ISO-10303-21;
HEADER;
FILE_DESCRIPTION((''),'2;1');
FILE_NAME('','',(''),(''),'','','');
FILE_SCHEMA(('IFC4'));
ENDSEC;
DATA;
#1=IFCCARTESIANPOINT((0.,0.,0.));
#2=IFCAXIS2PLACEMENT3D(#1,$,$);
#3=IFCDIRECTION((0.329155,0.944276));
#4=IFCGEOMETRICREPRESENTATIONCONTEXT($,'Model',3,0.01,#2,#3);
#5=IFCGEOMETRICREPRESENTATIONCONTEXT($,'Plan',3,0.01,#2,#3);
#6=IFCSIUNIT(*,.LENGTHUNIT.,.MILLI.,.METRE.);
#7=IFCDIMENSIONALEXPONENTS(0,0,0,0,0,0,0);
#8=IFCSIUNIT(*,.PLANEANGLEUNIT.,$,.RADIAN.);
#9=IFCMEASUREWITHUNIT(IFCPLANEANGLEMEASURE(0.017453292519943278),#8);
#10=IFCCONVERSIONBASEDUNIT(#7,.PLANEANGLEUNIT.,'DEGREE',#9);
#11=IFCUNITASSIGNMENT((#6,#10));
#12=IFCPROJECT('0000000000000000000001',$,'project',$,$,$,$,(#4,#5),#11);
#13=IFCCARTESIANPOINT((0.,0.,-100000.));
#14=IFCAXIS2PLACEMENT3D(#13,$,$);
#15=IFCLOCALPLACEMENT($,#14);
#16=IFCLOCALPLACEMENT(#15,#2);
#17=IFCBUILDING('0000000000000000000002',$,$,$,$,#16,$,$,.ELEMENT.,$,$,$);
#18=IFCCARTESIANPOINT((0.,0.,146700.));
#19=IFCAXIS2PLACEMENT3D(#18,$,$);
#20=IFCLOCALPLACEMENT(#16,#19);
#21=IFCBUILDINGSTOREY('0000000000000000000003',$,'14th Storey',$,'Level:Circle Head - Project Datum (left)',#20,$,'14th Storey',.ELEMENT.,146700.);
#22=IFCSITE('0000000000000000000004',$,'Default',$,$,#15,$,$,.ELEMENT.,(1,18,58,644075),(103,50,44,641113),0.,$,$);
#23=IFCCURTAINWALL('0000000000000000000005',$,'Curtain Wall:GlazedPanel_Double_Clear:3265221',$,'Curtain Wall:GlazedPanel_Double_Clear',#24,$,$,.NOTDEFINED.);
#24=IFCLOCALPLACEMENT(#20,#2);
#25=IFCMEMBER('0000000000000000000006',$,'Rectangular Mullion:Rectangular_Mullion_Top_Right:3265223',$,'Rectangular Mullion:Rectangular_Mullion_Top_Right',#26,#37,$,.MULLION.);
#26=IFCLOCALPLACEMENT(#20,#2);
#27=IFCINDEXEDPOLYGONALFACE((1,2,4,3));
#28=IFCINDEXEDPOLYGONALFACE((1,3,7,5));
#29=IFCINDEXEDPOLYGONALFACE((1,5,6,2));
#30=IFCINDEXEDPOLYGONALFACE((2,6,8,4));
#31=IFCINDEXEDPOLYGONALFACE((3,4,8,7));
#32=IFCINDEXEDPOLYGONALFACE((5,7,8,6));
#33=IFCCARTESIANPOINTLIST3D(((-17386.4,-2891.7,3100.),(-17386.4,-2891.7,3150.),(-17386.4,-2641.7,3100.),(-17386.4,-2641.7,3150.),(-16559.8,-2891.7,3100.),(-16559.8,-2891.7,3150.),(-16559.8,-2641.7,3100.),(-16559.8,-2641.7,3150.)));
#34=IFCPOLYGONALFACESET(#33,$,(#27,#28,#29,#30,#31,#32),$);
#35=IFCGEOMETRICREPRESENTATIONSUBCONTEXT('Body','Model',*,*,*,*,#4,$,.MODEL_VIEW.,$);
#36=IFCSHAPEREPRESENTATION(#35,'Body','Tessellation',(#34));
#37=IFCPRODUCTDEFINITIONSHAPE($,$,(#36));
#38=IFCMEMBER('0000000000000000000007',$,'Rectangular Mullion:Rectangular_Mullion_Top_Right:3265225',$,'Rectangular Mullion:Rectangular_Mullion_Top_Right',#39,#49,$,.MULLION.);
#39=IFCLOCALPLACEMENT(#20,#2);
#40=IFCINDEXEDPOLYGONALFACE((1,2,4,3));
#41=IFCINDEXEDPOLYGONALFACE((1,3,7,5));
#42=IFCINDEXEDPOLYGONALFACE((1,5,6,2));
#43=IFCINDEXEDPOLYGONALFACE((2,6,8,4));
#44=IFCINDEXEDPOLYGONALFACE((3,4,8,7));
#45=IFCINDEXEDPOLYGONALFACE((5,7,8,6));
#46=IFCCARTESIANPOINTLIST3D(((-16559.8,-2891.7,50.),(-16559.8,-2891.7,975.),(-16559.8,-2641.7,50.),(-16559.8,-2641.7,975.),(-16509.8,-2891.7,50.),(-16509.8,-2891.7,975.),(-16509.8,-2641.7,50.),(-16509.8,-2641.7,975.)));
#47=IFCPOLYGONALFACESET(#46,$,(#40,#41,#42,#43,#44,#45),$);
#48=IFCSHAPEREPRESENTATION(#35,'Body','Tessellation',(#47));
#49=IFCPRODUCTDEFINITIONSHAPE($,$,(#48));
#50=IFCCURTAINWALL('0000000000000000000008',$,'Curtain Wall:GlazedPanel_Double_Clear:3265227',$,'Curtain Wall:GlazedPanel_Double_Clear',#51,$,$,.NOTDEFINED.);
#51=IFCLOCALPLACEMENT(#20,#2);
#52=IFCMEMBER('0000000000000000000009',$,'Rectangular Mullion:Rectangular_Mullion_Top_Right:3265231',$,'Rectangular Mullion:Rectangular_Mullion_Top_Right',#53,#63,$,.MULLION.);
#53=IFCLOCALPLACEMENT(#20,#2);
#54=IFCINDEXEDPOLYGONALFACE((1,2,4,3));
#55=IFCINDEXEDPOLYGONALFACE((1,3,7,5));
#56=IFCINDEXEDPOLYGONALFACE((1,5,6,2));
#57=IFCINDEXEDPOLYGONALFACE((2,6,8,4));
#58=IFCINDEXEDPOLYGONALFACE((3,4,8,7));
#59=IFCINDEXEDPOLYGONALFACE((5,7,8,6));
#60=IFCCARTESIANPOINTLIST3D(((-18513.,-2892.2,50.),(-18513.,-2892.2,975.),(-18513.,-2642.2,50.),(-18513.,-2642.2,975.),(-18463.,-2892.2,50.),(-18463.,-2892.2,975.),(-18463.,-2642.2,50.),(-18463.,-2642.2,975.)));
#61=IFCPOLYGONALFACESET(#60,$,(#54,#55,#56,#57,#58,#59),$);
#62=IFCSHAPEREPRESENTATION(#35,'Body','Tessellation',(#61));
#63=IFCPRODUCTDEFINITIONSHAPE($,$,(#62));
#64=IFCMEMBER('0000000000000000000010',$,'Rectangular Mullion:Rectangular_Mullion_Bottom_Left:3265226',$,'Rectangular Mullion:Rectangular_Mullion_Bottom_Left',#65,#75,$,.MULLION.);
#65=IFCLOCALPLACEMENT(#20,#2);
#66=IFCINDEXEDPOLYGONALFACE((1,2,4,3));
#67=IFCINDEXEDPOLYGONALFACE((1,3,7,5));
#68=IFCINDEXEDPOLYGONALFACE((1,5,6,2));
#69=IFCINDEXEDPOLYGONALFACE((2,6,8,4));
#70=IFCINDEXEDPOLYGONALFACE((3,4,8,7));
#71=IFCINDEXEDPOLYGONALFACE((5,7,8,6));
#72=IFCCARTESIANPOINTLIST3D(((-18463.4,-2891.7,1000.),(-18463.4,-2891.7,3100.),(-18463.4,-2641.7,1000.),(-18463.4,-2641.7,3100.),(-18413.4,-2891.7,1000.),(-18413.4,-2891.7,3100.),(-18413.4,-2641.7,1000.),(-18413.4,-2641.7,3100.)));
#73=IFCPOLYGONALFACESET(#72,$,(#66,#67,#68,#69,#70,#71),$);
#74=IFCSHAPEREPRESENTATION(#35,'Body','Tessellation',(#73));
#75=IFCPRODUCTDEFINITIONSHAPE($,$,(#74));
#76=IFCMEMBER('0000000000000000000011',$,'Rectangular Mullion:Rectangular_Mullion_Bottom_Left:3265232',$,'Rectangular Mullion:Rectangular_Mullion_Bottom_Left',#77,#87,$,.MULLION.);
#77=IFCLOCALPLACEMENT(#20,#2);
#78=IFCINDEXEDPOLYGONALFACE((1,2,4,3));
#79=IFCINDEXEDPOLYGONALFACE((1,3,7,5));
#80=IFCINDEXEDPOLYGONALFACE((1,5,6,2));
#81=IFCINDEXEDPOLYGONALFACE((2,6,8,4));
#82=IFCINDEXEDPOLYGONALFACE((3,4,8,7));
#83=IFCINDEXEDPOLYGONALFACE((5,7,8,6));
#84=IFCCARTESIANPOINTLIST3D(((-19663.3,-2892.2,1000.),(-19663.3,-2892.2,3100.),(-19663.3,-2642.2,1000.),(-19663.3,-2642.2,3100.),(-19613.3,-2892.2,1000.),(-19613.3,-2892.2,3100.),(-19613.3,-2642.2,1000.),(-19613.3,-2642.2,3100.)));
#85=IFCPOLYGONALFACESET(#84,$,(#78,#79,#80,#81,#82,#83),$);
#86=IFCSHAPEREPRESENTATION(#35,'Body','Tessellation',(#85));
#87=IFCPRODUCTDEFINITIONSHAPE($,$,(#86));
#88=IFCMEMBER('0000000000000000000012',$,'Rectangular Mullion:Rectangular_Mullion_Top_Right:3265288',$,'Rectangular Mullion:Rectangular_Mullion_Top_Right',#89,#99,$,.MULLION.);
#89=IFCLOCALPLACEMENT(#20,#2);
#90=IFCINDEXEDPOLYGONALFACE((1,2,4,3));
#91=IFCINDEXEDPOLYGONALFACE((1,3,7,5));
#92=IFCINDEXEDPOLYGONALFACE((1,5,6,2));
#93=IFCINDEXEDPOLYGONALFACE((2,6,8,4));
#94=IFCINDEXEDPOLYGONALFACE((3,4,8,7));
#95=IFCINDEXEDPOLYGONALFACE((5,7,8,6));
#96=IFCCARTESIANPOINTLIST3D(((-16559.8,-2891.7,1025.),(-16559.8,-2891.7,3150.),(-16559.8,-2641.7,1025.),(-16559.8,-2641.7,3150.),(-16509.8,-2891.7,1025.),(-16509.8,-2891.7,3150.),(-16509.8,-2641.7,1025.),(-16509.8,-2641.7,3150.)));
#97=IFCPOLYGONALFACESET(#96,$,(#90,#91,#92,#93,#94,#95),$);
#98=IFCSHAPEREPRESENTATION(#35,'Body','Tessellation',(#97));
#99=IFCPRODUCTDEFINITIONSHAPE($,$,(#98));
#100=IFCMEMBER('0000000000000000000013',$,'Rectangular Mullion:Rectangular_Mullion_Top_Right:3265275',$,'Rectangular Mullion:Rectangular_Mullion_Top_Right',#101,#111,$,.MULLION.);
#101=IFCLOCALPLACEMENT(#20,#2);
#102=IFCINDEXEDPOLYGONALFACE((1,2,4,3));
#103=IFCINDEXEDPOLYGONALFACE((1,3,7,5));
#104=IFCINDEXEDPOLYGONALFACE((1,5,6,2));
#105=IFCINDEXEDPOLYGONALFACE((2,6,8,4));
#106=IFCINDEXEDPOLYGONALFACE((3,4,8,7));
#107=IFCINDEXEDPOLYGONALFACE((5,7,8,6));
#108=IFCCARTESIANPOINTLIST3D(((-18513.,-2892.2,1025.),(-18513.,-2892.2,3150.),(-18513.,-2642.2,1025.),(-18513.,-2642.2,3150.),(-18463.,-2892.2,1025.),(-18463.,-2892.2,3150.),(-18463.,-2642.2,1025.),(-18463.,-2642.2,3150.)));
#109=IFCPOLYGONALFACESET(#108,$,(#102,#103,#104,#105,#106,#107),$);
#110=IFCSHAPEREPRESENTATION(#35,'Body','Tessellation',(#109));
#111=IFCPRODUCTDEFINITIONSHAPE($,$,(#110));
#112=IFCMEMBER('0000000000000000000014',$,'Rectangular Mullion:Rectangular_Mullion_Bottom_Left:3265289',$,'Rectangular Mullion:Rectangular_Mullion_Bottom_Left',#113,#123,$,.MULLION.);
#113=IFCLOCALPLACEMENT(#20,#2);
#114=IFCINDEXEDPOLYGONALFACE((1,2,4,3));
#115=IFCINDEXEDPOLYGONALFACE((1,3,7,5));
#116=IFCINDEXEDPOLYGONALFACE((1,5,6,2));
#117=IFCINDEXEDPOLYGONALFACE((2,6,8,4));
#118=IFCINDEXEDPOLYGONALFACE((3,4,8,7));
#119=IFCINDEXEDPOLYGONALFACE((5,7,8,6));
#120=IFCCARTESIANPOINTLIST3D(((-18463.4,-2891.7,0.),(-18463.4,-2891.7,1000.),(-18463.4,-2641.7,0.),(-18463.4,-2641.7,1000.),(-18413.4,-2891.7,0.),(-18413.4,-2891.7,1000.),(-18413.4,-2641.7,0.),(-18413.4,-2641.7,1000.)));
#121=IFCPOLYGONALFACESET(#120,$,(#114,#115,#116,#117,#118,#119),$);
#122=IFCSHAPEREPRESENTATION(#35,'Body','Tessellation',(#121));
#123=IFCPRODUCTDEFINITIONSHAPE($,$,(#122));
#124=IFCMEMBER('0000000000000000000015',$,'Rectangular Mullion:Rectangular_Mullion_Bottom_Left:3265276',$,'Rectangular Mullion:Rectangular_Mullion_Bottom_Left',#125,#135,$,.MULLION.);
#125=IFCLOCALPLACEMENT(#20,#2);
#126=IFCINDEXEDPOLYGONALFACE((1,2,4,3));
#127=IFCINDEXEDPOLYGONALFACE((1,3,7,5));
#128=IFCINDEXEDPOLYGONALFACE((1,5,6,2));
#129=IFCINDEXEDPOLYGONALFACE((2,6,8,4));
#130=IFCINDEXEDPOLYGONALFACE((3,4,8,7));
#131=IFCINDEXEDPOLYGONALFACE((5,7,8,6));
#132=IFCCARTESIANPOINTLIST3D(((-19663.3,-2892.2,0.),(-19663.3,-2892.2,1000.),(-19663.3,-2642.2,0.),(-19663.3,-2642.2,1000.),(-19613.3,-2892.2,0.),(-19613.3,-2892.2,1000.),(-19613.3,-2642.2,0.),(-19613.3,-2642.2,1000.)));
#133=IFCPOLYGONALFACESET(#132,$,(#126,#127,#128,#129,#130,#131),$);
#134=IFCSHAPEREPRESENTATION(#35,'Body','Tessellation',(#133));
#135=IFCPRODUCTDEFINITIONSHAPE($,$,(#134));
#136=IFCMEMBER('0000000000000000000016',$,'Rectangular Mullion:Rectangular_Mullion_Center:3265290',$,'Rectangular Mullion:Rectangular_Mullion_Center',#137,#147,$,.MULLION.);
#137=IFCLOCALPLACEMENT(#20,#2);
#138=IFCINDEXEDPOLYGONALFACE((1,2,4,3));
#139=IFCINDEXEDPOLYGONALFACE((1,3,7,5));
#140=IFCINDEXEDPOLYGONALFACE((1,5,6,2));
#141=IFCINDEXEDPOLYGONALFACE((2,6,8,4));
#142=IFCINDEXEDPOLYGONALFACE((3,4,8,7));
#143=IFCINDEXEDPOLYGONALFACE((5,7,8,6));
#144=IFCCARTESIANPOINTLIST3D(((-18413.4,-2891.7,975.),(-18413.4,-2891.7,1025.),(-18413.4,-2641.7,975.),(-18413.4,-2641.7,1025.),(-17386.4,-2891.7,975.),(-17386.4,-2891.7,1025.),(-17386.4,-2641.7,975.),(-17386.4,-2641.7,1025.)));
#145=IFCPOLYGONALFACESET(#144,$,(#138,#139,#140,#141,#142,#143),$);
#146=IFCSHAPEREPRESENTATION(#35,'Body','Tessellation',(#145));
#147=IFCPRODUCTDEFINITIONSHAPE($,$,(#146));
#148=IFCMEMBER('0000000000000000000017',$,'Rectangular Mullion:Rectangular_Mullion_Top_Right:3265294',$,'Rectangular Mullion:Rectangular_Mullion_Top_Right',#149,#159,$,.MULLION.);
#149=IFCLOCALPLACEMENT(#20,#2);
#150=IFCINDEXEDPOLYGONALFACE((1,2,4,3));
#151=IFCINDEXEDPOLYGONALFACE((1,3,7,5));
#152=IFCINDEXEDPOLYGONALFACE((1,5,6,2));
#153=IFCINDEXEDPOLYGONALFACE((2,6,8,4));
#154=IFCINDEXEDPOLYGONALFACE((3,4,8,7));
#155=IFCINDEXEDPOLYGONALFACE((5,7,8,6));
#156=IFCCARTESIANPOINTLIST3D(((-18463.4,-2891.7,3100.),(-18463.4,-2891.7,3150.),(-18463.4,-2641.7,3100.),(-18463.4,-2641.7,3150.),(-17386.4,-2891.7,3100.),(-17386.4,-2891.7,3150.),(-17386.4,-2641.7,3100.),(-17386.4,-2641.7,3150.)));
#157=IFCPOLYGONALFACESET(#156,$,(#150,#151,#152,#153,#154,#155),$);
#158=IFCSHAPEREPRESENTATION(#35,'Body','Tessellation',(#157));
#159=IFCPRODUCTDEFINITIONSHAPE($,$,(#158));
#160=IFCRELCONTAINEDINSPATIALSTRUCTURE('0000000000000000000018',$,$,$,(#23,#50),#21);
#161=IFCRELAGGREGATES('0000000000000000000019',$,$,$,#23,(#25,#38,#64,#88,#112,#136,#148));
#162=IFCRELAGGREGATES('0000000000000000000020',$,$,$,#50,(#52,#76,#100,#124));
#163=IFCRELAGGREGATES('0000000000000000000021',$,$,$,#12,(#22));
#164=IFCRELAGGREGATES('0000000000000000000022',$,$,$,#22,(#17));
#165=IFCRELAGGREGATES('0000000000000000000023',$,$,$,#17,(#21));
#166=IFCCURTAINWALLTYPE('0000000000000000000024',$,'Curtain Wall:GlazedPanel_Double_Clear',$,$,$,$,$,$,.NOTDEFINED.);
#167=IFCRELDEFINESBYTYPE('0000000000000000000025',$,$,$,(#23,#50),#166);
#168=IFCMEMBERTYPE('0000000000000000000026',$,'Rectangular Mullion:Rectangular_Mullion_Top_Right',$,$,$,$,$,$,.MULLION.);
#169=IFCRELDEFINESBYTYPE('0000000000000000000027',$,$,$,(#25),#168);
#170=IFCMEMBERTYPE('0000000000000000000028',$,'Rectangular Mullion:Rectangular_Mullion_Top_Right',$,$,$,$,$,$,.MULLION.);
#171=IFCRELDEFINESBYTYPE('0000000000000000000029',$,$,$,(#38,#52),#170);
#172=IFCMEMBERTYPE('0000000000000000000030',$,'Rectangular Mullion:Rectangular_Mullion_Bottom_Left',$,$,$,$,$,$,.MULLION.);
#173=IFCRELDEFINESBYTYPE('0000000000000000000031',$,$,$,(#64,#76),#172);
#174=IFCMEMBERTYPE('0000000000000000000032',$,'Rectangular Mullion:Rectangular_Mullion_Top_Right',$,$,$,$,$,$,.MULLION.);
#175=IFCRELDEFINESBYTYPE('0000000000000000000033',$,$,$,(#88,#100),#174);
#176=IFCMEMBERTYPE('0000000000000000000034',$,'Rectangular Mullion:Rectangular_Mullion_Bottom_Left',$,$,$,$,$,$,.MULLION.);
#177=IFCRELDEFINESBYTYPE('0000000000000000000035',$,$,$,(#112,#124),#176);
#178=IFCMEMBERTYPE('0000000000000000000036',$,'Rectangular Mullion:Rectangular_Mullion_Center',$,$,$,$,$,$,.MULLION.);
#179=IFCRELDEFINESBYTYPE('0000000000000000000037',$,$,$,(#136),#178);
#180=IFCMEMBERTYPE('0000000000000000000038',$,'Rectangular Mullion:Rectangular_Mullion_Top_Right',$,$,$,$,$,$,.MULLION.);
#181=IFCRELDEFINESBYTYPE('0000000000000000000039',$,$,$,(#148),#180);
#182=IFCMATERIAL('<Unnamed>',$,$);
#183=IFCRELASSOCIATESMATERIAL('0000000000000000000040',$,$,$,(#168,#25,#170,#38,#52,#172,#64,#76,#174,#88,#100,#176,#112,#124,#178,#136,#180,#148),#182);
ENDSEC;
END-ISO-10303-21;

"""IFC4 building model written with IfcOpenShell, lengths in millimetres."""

from ifc_helpers import new_model, entity, si_unit, converted_unit, direction, frame, origin, place, context, subcontext, project, spatial, indexed_curve, outline, extrude, source, transform, mapped, material, type_object, type_shapes, element, aggregate, save


model = new_model("IFC4")

# Units and contexts
model_context = context("Model", 3, precision=0.01, world=origin(), true_north=direction((0.329155, 0.944276)))
plan_context = context("Plan", 3, precision=0.01, world=origin(), true_north=direction((0.329155, 0.944276)))
body_context = subcontext(model_context, "Body", "Model", "MODEL_VIEW")
ifc_project = project(units=[si_unit("LENGTHUNIT", "METRE", prefix="MILLI"), converted_unit("PLANEANGLEUNIT", "DEGREE", entity("IfcPlaneAngleMeasure", 0.017453292519943278), si_unit("PLANEANGLEUNIT", "RADIAN"), dimensions=[0, 0, 0, 0, 0, 0, 0])], contexts=[model_context, plan_context])

# Site, building, storey
site_placement = place(None, frame((0.0, 0.0, -100000.0)))
site = spatial("IfcSite", under=ifc_project, at=site_placement, Name="Default", CompositionType="ELEMENT", RefLatitude=(1, 18, 58, 644075), RefLongitude=(103, 50, 44, 641113), RefElevation=0.0)
building_placement = place(site_placement, origin())
building = spatial("IfcBuilding", under=site, at=building_placement, CompositionType="ELEMENT")
storey_placement = place(building_placement, frame((0.0, 0.0, 146700.0)))
storey = spatial("IfcBuildingStorey", under=building, at=storey_placement, Name="14th Storey", ObjectType="Level:Circle Head - Project Datum (left)", LongName="14th Storey", CompositionType="ELEMENT", Elevation=146700.0)

# Curtain wall, members
curtain_wall_type = type_object("IfcCurtainWallType", Name="Curtain Wall:GlazedPanel_Double_Clear", PredefinedType="NOTDEFINED")
curtain_wall_1_placement = place(storey_placement, frame((0.0, 0.0, -146700.0)))
curtain_wall_1 = element("IfcCurtainWall", 1, at=curtain_wall_1_placement, inside=storey, type_object=curtain_wall_type, Name="Curtain Wall:GlazedPanel_Double_Clear:3265221", ObjectType="Curtain Wall:GlazedPanel_Double_Clear", PredefinedType="NOTDEFINED")
ifc_material_1 = material(Name="<Unnamed>")
member_type_1 = type_object("IfcMemberType", Name="Rectangular Mullion:Rectangular_Mullion_Top_Right", PredefinedType="MULLION", material=ifc_material_1)
shared_shape_1 = source(origin(), body_context, "Body", "SweptSolid", [
    extrude(outline(indexed_curve([(-25.0, -125.0), (25.0, -125.0), (25.0, 125.0), (-25.0, 125.0), (-25.0, -125.0)], self_intersect=False)), frame((-25.0, 0.0, -826.6), z_axis=(0.0, 0.0, 1.0), x_axis=(-1.0, 0.0, 0.0)), (0.0, 0.0, 1.0), 826.6),
])
type_shapes(member_type_1, [shared_shape_1])
member_1_placement = place(curtain_wall_1_placement, frame((-16559.8, -2766.7, 149850.0), z_axis=(1.0, 0.0, 0.0), x_axis=(0.0, 0.0, 1.0)))
member_1 = element("IfcMember", 2, at=member_1_placement, type_object=member_type_1, material=ifc_material_1, Name="Rectangular Mullion:Rectangular_Mullion_Top_Right:3265223", ObjectType="Rectangular Mullion:Rectangular_Mullion_Top_Right", PredefinedType="MULLION", context=body_context, shape_type="MappedRepresentation", body=[
    mapped(shared_shape_1, transform((0.0, 0.0, 0.0), scale=1.0)),
])
member_type_2 = type_object("IfcMemberType", Name="Rectangular Mullion:Rectangular_Mullion_Top_Right", PredefinedType="MULLION", material=ifc_material_1)
shared_shape_2 = source(origin(), body_context, "Body", "SweptSolid", [
    extrude(outline(indexed_curve([(-25.0, -125.0), (25.0, -125.0), (25.0, 125.0), (-25.0, 125.0), (-25.0, -125.0)], self_intersect=False)), frame((-25.0, 0.0, -925.0), z_axis=(0.0, 0.0, 1.0), x_axis=(-1.0, 0.0, 0.0)), (0.0, 0.0, 1.0), 925.0),
])
type_shapes(member_type_2, [shared_shape_2])
member_2_placement = place(curtain_wall_1_placement, frame((-16509.8, -2766.7, 146750.0), z_axis=(0.0, 0.0, -1.0), x_axis=(1.0, 0.0, 0.0)))
member_2 = element("IfcMember", 3, at=member_2_placement, type_object=member_type_2, material=ifc_material_1, Name="Rectangular Mullion:Rectangular_Mullion_Top_Right:3265225", ObjectType="Rectangular Mullion:Rectangular_Mullion_Top_Right", PredefinedType="MULLION", context=body_context, shape_type="MappedRepresentation", body=[
    mapped(shared_shape_2, transform((0.0, 0.0, 0.0), scale=1.0)),
])

# Curtain wall, member
curtain_wall_2_placement = place(storey_placement, frame((0.0, 0.0, -146700.0)))
curtain_wall_2 = element("IfcCurtainWall", 4, at=curtain_wall_2_placement, inside=storey, type_object=curtain_wall_type, Name="Curtain Wall:GlazedPanel_Double_Clear:3265227", ObjectType="Curtain Wall:GlazedPanel_Double_Clear", PredefinedType="NOTDEFINED")
member_3_placement = place(curtain_wall_2_placement, frame((-18463.0, -2767.2, 146750.0), z_axis=(0.0, 0.0, -1.0), x_axis=(1.0, 0.0, 0.0)))
member_3 = element("IfcMember", 5, at=member_3_placement, type_object=member_type_2, material=ifc_material_1, Name="Rectangular Mullion:Rectangular_Mullion_Top_Right:3265231", ObjectType="Rectangular Mullion:Rectangular_Mullion_Top_Right", PredefinedType="MULLION", context=body_context, shape_type="MappedRepresentation", body=[
    mapped(shared_shape_2, transform((0.0, 0.0, 0.0), scale=1.0)),
])

# Members
member_type_3 = type_object("IfcMemberType", Name="Rectangular Mullion:Rectangular_Mullion_Bottom_Left", PredefinedType="MULLION", material=ifc_material_1)
shared_shape_3 = source(origin(), body_context, "Body", "SweptSolid", [
    extrude(outline(indexed_curve([(-25.0, -125.0), (25.0, -125.0), (25.0, 125.0), (-25.0, 125.0), (-25.0, -125.0)], self_intersect=False)), frame((-25.0, 0.0, -2100.0), z_axis=(0.0, 0.0, 1.0), x_axis=(-1.0, 0.0, 0.0)), (0.0, 0.0, 1.0), 2100.0),
])
type_shapes(member_type_3, [shared_shape_3])
member_4_placement = place(curtain_wall_1_placement, frame((-18463.4, -2766.7, 149800.0), z_axis=(0.0, 0.0, 1.0), x_axis=(-1.0, 0.0, 0.0)))
member_4 = element("IfcMember", 6, at=member_4_placement, type_object=member_type_3, material=ifc_material_1, Name="Rectangular Mullion:Rectangular_Mullion_Bottom_Left:3265226", ObjectType="Rectangular Mullion:Rectangular_Mullion_Bottom_Left", PredefinedType="MULLION", context=body_context, shape_type="MappedRepresentation", body=[
    mapped(shared_shape_3, transform((0.0, 0.0, 0.0), scale=1.0)),
])
member_5_placement = place(curtain_wall_2_placement, frame((-19663.3, -2767.2, 149800.0), z_axis=(0.0, 0.0, 1.0), x_axis=(-1.0, 0.0, 0.0)))
member_5 = element("IfcMember", 7, at=member_5_placement, type_object=member_type_3, material=ifc_material_1, Name="Rectangular Mullion:Rectangular_Mullion_Bottom_Left:3265232", ObjectType="Rectangular Mullion:Rectangular_Mullion_Bottom_Left", PredefinedType="MULLION", context=body_context, shape_type="MappedRepresentation", body=[
    mapped(shared_shape_3, transform((0.0, 0.0, 0.0), scale=1.0)),
])
member_type_4 = type_object("IfcMemberType", Name="Rectangular Mullion:Rectangular_Mullion_Top_Right", PredefinedType="MULLION", material=ifc_material_1)
shared_shape_4 = source(origin(), body_context, "Body", "SweptSolid", [
    extrude(outline(indexed_curve([(-25.0, -125.0), (25.0, -125.0), (25.0, 125.0), (-25.0, 125.0), (-25.0, -125.0)], self_intersect=False)), frame((-25.0, 0.0, -2125.0), z_axis=(0.0, 0.0, 1.0), x_axis=(-1.0, 0.0, 0.0)), (0.0, 0.0, 1.0), 2125.0),
])
type_shapes(member_type_4, [shared_shape_4])
member_6_placement = place(curtain_wall_1_placement, frame((-16509.8, -2766.7, 147725.0), z_axis=(0.0, 0.0, -1.0), x_axis=(1.0, 0.0, 0.0)))
member_6 = element("IfcMember", 8, at=member_6_placement, type_object=member_type_4, material=ifc_material_1, Name="Rectangular Mullion:Rectangular_Mullion_Top_Right:3265288", ObjectType="Rectangular Mullion:Rectangular_Mullion_Top_Right", PredefinedType="MULLION", context=body_context, shape_type="MappedRepresentation", body=[
    mapped(shared_shape_4, transform((0.0, 0.0, 0.0), scale=1.0)),
])
member_7_placement = place(curtain_wall_2_placement, frame((-18463.0, -2767.2, 147725.0), z_axis=(0.0, 0.0, -1.0), x_axis=(1.0, 0.0, 0.0)))
member_7 = element("IfcMember", 9, at=member_7_placement, type_object=member_type_4, material=ifc_material_1, Name="Rectangular Mullion:Rectangular_Mullion_Top_Right:3265275", ObjectType="Rectangular Mullion:Rectangular_Mullion_Top_Right", PredefinedType="MULLION", context=body_context, shape_type="MappedRepresentation", body=[
    mapped(shared_shape_4, transform((0.0, 0.0, 0.0), scale=1.0)),
])
member_type_5 = type_object("IfcMemberType", Name="Rectangular Mullion:Rectangular_Mullion_Bottom_Left", PredefinedType="MULLION", material=ifc_material_1)
shared_shape_5 = source(origin(), body_context, "Body", "SweptSolid", [
    extrude(outline(indexed_curve([(-25.0, -125.0), (25.0, -125.0), (25.0, 125.0), (-25.0, 125.0), (-25.0, -125.0)], self_intersect=False)), frame((-25.0, 0.0, -1000.0), z_axis=(0.0, 0.0, 1.0), x_axis=(-1.0, 0.0, 0.0)), (0.0, 0.0, 1.0), 1000.0),
])
type_shapes(member_type_5, [shared_shape_5])
member_8_placement = place(curtain_wall_1_placement, frame((-18463.4, -2766.7, 147700.0), z_axis=(0.0, 0.0, 1.0), x_axis=(-1.0, 0.0, 0.0)))
member_8 = element("IfcMember", 10, at=member_8_placement, type_object=member_type_5, material=ifc_material_1, Name="Rectangular Mullion:Rectangular_Mullion_Bottom_Left:3265289", ObjectType="Rectangular Mullion:Rectangular_Mullion_Bottom_Left", PredefinedType="MULLION", context=body_context, shape_type="MappedRepresentation", body=[
    mapped(shared_shape_5, transform((0.0, 0.0, 0.0), scale=1.0)),
])
member_9_placement = place(curtain_wall_2_placement, frame((-19663.3, -2767.2, 147700.0), z_axis=(0.0, 0.0, 1.0), x_axis=(-1.0, 0.0, 0.0)))
member_9 = element("IfcMember", 11, at=member_9_placement, type_object=member_type_5, material=ifc_material_1, Name="Rectangular Mullion:Rectangular_Mullion_Bottom_Left:3265276", ObjectType="Rectangular Mullion:Rectangular_Mullion_Bottom_Left", PredefinedType="MULLION", context=body_context, shape_type="MappedRepresentation", body=[
    mapped(shared_shape_5, transform((0.0, 0.0, 0.0), scale=1.0)),
])
member_type_6 = type_object("IfcMemberType", Name="Rectangular Mullion:Rectangular_Mullion_Center", PredefinedType="MULLION", material=ifc_material_1)
shared_shape_6 = source(origin(), body_context, "Body", "SweptSolid", [
    extrude(outline(indexed_curve([(-25.0, -125.0), (25.0, -125.0), (25.0, 125.0), (-25.0, 125.0), (-25.0, -125.0)], self_intersect=False)), frame((0.0, 0.0, -1027.0), z_axis=(0.0, 0.0, 1.0), x_axis=(-1.0, 0.0, 0.0)), (0.0, 0.0, 1.0), 1027.0),
])
type_shapes(member_type_6, [shared_shape_6])
member_10_placement = place(curtain_wall_1_placement, frame((-17386.4, -2766.7, 147700.0), z_axis=(1.0, 0.0, 0.0), x_axis=(0.0, 0.0, 1.0)))
member_10 = element("IfcMember", 12, at=member_10_placement, type_object=member_type_6, material=ifc_material_1, Name="Rectangular Mullion:Rectangular_Mullion_Center:3265290", ObjectType="Rectangular Mullion:Rectangular_Mullion_Center", PredefinedType="MULLION", context=body_context, shape_type="MappedRepresentation", body=[
    mapped(shared_shape_6, transform((0.0, 0.0, 0.0), scale=1.0)),
])
member_type_7 = type_object("IfcMemberType", Name="Rectangular Mullion:Rectangular_Mullion_Top_Right", PredefinedType="MULLION", material=ifc_material_1)
shared_shape_7 = source(origin(), body_context, "Body", "SweptSolid", [
    extrude(outline(indexed_curve([(-25.0, -125.0), (25.0, -125.0), (25.0, 125.0), (-25.0, 125.0), (-25.0, -125.0)], self_intersect=False)), frame((-25.0, 0.0, -1077.0), z_axis=(0.0, 0.0, 1.0), x_axis=(-1.0, 0.0, 0.0)), (0.0, 0.0, 1.0), 1077.0),
])
type_shapes(member_type_7, [shared_shape_7])
member_11_placement = place(curtain_wall_1_placement, frame((-17386.4, -2766.7, 149850.0), z_axis=(1.0, 0.0, 0.0), x_axis=(0.0, 0.0, 1.0)))
member_11 = element("IfcMember", 13, at=member_11_placement, type_object=member_type_7, material=ifc_material_1, Name="Rectangular Mullion:Rectangular_Mullion_Top_Right:3265294", ObjectType="Rectangular Mullion:Rectangular_Mullion_Top_Right", PredefinedType="MULLION", context=body_context, shape_type="MappedRepresentation", body=[
    mapped(shared_shape_7, transform((0.0, 0.0, 0.0), scale=1.0)),
])

aggregate(curtain_wall_1, [member_1, member_2, member_4, member_6, member_8, member_10, member_11])
aggregate(curtain_wall_2, [member_3, member_5, member_7, member_9])

save(model, "model.ifc")
